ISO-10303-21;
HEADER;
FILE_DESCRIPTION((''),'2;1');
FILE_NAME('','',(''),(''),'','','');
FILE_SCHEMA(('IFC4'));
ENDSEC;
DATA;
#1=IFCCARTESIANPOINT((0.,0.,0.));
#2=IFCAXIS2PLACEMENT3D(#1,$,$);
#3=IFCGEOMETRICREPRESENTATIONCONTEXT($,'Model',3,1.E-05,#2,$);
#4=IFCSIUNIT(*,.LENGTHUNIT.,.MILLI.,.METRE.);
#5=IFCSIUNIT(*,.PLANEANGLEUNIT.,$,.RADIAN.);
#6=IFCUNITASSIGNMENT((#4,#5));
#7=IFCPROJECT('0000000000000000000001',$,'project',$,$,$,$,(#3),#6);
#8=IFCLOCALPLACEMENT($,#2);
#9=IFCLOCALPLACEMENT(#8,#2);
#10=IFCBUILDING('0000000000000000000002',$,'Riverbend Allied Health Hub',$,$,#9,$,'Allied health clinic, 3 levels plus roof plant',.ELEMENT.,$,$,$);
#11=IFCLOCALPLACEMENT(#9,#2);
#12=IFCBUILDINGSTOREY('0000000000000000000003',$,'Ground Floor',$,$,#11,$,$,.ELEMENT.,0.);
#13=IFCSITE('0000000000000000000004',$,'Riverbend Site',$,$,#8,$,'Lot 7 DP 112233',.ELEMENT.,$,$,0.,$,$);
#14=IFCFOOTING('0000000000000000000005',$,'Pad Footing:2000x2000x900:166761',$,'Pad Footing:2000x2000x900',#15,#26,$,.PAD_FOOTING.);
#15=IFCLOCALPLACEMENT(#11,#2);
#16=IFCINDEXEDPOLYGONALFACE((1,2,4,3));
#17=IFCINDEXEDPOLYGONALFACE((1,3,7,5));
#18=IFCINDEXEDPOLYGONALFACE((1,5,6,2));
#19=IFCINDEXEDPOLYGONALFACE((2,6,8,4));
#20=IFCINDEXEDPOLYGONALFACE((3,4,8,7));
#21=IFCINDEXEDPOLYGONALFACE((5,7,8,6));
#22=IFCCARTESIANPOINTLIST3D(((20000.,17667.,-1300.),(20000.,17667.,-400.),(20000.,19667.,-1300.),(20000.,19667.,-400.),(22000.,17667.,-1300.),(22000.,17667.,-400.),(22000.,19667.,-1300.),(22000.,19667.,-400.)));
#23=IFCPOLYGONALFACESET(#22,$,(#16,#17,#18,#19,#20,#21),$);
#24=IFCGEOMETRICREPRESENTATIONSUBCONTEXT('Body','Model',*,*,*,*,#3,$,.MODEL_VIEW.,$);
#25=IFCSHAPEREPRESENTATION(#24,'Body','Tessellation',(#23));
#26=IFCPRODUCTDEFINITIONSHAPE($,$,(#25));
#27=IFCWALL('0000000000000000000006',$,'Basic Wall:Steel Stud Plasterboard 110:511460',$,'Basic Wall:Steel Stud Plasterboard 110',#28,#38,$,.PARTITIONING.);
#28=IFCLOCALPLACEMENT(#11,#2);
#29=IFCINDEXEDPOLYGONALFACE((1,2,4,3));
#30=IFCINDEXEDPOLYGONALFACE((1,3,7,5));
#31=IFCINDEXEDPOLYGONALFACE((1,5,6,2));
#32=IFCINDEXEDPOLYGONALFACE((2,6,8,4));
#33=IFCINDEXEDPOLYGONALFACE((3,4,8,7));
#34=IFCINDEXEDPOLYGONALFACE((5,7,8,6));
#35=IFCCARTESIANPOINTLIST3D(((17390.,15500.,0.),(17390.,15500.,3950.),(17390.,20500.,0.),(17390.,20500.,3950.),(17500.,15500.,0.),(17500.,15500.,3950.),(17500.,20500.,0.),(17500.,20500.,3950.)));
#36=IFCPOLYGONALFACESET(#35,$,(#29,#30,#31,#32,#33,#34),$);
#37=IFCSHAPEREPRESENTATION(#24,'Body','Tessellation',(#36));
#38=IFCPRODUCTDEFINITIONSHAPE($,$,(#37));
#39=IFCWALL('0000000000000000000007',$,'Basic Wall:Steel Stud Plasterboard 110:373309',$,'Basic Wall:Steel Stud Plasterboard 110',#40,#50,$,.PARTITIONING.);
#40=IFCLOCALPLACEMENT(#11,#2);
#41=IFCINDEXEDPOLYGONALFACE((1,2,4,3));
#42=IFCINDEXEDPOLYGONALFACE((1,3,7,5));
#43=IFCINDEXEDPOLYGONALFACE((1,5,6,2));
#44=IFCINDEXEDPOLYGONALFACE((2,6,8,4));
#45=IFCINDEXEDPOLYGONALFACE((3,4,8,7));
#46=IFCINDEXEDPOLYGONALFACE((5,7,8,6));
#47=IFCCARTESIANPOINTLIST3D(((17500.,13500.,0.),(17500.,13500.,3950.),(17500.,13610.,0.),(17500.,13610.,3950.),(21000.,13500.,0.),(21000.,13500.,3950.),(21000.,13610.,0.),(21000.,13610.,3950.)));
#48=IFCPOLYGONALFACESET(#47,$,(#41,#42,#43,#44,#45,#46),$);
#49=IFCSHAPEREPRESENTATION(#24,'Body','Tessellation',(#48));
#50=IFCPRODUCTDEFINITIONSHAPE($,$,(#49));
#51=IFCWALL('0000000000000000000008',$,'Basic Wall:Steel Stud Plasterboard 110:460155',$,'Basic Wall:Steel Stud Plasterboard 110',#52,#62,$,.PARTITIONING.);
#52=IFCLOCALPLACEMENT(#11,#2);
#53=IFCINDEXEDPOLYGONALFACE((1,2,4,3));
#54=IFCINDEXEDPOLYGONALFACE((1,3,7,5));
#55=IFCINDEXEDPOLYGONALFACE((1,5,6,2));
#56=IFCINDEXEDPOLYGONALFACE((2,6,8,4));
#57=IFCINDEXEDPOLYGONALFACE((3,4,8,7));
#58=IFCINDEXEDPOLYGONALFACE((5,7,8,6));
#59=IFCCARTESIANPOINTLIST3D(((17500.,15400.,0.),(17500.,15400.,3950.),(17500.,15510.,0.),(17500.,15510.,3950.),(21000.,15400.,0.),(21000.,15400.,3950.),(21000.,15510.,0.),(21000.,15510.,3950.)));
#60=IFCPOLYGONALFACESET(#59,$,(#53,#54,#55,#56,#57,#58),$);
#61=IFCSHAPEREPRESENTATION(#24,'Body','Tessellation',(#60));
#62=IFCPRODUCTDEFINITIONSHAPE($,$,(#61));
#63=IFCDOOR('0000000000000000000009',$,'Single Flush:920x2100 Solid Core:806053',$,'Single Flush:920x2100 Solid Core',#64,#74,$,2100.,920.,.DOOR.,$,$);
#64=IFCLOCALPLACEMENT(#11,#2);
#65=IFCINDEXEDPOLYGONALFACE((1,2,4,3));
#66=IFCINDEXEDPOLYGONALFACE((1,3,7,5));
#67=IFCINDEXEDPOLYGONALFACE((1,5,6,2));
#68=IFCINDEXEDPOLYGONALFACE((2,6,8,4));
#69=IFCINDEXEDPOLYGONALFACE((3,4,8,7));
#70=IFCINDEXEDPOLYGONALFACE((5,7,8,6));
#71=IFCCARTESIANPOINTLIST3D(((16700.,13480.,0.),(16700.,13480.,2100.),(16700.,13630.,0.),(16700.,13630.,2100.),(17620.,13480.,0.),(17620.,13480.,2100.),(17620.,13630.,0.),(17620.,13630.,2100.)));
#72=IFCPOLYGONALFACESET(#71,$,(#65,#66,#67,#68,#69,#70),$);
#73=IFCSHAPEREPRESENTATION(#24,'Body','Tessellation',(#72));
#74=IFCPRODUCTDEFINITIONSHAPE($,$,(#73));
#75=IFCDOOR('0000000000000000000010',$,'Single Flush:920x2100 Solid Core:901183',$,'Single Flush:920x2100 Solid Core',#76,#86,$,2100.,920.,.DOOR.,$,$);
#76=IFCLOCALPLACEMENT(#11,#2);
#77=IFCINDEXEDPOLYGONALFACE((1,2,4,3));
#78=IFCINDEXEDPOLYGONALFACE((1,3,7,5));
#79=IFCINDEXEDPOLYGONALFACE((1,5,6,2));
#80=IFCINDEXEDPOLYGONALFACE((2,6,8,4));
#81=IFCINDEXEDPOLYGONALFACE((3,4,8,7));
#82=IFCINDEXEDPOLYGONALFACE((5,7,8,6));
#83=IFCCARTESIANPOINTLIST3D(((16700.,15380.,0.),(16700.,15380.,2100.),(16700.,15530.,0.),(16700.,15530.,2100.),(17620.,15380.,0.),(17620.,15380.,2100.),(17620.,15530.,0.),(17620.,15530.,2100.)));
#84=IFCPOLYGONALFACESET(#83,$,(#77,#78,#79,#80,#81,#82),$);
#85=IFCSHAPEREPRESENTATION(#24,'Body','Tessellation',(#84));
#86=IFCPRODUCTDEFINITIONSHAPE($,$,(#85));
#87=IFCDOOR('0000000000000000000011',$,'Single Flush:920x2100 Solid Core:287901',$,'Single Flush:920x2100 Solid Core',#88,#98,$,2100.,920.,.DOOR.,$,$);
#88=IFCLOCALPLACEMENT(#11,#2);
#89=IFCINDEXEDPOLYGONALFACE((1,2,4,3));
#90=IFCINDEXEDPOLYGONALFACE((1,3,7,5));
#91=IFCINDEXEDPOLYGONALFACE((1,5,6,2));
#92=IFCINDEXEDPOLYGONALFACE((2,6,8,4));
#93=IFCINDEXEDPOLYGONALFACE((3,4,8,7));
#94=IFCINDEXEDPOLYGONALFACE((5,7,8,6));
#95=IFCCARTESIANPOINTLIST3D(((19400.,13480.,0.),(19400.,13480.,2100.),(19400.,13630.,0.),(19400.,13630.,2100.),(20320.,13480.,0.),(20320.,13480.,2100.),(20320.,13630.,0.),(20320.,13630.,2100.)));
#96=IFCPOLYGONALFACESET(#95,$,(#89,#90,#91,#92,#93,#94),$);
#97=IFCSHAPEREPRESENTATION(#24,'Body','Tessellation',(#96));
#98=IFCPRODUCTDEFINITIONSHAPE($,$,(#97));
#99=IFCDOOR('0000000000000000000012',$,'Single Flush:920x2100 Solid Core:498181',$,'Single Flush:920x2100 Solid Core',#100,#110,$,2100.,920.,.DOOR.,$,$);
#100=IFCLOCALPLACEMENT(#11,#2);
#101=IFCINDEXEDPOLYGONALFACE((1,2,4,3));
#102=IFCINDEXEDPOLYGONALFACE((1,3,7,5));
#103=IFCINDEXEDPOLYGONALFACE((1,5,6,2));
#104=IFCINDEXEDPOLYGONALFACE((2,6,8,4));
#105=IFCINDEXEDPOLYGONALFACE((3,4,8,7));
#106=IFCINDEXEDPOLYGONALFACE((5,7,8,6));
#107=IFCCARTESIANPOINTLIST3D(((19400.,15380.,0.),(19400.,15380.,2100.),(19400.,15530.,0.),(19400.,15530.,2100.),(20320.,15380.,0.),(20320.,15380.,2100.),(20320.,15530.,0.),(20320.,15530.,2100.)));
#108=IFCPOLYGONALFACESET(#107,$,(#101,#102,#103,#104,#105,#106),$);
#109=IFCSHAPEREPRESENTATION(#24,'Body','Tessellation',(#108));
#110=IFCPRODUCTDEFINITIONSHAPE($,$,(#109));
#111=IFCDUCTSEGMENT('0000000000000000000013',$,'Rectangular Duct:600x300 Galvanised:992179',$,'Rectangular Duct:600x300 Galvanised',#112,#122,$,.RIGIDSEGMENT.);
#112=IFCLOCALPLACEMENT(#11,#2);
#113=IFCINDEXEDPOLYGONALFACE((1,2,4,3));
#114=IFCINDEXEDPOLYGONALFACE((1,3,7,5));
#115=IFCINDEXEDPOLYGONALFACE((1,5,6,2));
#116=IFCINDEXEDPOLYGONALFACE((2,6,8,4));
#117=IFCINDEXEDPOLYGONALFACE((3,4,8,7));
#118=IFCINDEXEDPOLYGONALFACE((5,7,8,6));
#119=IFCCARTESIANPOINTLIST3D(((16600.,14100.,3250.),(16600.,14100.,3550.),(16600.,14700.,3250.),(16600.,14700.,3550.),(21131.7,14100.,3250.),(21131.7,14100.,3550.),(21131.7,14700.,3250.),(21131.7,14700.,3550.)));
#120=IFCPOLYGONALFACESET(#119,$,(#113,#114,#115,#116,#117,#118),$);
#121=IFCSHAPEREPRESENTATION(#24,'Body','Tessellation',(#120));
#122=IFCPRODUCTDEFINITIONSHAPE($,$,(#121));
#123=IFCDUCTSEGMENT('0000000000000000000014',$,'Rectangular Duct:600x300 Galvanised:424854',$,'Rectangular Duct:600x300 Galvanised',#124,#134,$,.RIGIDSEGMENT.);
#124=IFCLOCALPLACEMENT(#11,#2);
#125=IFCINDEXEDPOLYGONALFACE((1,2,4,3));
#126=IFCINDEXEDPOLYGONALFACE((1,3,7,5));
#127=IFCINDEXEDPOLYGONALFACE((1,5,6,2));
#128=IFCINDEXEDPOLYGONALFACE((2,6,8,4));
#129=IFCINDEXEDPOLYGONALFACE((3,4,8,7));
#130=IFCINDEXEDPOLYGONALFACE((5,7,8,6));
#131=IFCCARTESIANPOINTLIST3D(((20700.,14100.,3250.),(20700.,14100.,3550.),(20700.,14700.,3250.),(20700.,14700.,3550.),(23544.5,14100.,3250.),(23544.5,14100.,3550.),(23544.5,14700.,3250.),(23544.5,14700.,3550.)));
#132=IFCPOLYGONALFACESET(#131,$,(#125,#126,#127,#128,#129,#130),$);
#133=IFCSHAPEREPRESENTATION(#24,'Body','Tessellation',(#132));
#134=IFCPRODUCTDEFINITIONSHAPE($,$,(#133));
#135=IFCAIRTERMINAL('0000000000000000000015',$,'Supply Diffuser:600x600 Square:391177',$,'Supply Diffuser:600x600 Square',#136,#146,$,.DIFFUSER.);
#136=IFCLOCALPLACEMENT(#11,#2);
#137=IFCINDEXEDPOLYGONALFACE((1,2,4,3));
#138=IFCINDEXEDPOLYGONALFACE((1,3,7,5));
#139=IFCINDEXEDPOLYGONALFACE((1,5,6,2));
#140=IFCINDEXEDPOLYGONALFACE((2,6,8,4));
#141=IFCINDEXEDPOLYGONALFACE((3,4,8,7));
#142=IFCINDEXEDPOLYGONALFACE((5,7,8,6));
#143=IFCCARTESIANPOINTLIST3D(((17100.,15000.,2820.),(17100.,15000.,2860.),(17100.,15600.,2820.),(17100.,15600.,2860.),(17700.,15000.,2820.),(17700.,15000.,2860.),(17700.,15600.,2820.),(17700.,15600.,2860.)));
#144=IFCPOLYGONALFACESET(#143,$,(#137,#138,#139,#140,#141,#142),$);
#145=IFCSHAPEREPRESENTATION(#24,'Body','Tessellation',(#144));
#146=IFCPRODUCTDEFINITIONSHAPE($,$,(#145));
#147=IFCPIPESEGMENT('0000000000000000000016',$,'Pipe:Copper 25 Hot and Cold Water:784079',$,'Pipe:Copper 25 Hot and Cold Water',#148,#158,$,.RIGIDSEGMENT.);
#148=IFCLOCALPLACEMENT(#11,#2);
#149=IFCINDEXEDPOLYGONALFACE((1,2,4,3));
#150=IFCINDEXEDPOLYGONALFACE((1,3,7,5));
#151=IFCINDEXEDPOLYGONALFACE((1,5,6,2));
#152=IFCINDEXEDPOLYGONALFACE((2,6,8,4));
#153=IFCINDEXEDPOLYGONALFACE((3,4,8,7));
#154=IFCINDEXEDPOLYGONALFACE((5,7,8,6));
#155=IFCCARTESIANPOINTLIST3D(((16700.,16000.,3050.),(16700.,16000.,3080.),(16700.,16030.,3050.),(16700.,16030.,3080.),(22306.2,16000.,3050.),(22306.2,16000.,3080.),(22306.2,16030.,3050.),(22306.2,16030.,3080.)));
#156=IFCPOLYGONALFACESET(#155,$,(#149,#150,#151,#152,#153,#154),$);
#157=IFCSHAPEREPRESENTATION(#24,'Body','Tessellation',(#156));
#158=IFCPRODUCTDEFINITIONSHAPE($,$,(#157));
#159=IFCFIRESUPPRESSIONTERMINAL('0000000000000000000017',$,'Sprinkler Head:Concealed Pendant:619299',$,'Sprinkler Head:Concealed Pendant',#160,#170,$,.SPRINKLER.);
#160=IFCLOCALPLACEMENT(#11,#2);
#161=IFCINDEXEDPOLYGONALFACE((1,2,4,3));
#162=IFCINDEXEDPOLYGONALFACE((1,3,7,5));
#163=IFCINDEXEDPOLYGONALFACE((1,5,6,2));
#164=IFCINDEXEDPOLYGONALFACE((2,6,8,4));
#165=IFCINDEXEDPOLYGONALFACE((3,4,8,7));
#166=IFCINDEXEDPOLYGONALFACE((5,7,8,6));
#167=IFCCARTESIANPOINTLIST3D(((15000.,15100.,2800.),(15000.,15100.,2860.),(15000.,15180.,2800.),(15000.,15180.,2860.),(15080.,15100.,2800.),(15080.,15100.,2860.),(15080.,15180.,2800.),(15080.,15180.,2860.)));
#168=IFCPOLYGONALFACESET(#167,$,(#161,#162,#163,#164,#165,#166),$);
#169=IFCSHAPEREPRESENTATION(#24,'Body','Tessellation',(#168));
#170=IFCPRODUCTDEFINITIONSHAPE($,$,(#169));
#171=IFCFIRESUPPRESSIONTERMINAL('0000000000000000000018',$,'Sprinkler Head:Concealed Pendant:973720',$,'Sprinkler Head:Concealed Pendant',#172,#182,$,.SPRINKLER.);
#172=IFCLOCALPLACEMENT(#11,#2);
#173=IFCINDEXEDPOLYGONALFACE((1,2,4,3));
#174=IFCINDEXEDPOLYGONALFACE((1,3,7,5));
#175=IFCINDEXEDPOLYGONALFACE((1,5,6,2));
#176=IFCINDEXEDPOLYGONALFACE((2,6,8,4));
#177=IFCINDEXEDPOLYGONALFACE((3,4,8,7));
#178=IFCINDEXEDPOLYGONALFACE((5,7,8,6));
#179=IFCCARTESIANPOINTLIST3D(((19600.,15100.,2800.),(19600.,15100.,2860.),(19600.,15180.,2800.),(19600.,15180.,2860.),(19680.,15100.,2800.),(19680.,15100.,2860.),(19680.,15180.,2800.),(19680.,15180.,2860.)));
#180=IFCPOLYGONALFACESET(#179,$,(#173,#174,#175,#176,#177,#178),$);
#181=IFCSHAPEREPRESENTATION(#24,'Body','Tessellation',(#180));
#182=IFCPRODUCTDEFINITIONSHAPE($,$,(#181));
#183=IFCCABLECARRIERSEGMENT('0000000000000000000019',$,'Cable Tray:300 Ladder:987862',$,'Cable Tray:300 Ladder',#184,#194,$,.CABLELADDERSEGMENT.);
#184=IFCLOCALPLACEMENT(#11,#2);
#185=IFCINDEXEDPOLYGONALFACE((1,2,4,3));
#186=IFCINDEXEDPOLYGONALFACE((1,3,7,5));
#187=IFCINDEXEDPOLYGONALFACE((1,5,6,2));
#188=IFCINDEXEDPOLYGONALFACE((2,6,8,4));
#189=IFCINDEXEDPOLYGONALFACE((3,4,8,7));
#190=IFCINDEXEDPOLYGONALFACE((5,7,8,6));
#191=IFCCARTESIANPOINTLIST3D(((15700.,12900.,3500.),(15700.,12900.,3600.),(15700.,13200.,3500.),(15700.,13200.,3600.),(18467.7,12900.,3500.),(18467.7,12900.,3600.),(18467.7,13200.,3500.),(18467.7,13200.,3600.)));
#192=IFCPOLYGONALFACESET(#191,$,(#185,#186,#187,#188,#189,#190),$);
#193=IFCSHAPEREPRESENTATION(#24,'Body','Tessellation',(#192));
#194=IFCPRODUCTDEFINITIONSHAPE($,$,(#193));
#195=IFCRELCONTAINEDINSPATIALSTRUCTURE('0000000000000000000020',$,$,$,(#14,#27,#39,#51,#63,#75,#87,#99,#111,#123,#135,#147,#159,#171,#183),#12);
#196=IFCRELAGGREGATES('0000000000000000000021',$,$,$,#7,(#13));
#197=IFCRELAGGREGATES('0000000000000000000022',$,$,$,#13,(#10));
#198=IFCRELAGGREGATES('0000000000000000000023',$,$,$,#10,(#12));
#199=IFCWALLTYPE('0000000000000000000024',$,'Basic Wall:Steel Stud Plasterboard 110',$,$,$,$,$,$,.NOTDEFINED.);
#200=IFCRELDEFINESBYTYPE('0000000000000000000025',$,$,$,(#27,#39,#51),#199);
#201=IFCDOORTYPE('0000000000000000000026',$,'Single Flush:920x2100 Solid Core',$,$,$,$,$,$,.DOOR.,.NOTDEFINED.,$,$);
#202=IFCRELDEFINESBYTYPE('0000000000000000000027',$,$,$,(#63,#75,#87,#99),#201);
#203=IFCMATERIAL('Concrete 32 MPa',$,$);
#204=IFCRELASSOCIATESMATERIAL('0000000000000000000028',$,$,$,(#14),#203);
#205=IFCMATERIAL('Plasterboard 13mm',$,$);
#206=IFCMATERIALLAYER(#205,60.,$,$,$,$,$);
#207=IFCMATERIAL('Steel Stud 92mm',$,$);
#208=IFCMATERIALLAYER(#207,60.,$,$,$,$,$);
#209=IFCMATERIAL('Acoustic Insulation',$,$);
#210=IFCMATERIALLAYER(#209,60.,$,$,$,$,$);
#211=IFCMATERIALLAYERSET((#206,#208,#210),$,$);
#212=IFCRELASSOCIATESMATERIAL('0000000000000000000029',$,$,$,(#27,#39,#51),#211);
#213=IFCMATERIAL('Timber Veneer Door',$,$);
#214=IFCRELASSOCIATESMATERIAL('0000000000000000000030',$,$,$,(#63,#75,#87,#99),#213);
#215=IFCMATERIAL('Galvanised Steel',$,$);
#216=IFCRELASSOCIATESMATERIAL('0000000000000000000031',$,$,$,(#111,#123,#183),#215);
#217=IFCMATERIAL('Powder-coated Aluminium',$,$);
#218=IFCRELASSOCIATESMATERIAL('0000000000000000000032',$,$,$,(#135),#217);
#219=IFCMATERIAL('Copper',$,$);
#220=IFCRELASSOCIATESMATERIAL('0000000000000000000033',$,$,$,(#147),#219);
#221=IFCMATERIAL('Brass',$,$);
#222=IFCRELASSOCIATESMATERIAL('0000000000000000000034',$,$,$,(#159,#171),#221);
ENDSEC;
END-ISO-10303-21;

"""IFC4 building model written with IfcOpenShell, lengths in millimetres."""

from ifc_helpers import new_model, si_unit, frame, frame_2d, origin, place, context, subcontext, project, spatial, rectangle, extrude, material, layer, layer_set, layer_usage, type_object, element, save


model = new_model("IFC4")

# Units and contexts
model_context = context("Model", 3, precision=1e-05, world=origin())
body_context = subcontext(model_context, "Body", "Model", "MODEL_VIEW")
ifc_project = project(units=[si_unit("LENGTHUNIT", "METRE", prefix="MILLI"), si_unit("PLANEANGLEUNIT", "RADIAN")], contexts=[model_context])

# Site, building, storey
site_placement = place(None, origin())
site = spatial("IfcSite", under=ifc_project, at=site_placement, Name="Riverbend Site", LongName="Lot 7 DP 112233", CompositionType="ELEMENT", RefElevation=0.0)
building_placement = place(site_placement, origin())
building = spatial("IfcBuilding", under=site, at=building_placement, Name="Riverbend Allied Health Hub", LongName="Allied health clinic, 3 levels plus roof plant", CompositionType="ELEMENT")
storey_placement = place(building_placement, origin())
storey = spatial("IfcBuildingStorey", under=building, at=storey_placement, Name="Ground Floor", CompositionType="ELEMENT", Elevation=0.0)

# Footing
ifc_material_1 = material(Name="Concrete 32 MPa")
footing_placement = place(storey_placement, frame((20000.0, 17667.0, -1300.0)))
element("IfcFooting", 1, at=footing_placement, inside=storey, material=ifc_material_1, Name="Pad Footing:2000x2000x900:166761", ObjectType="Pad Footing:2000x2000x900", PredefinedType="PAD_FOOTING", context=body_context, shape_type="SweptSolid", body=[
    extrude(rectangle(XDim=2000.0, YDim=2000.0, at=frame_2d((1000.0, 1000.0))), origin(), (0.0, 0.0, 1.0), 900.0),
])

# Walls
ifc_material_2 = material(Name="Plasterboard 13mm")
ifc_layer_1 = layer(ifc_material_2, 60.0)
ifc_material_3 = material(Name="Steel Stud 92mm")
ifc_layer_2 = layer(ifc_material_3, 60.0)
ifc_material_4 = material(Name="Acoustic Insulation")
ifc_layer_3 = layer(ifc_material_4, 60.0)
ifc_layer_set = layer_set([ifc_layer_1, ifc_layer_2, ifc_layer_3])
ifc_layer_usage = layer_usage(ifc_layer_set, "AXIS2", "POSITIVE", 0.0)
wall_type = type_object("IfcWallType", Name="Basic Wall:Steel Stud Plasterboard 110", PredefinedType="NOTDEFINED")
wall_placement = place(storey_placement, frame((17500.0, 15500.0, 0.0), z_axis=(0.0, 0.0, 1.0), x_axis=(0.0, 1.0, 0.0)))
element("IfcWall", 2, at=wall_placement, inside=storey, type_object=wall_type, material=ifc_layer_usage, Name="Basic Wall:Steel Stud Plasterboard 110:511460", ObjectType="Basic Wall:Steel Stud Plasterboard 110", PredefinedType="PARTITIONING", context=body_context, shape_type="SweptSolid", body=[
    extrude(rectangle(XDim=5000.0, YDim=110.0, at=frame_2d((2500.0, 55.0))), origin(), (0.0, 0.0, 1.0), 3950.0),
])
for number, where, name in (
    (3, (17500.0, 13500.0, 0.0), "Basic Wall:Steel Stud Plasterboard 110:373309"),
    (4, (17500.0, 15400.0, 0.0), "Basic Wall:Steel Stud Plasterboard 110:460155"),
):
    element("IfcWall", number, at=place(storey_placement, frame(where)), inside=storey, type_object=wall_type, material=ifc_layer_usage, Name=name, ObjectType="Basic Wall:Steel Stud Plasterboard 110", PredefinedType="PARTITIONING", context=body_context, shape_type="SweptSolid", body=[
        extrude(rectangle(XDim=3500.0, YDim=110.0, at=frame_2d((1750.0, 55.0))), origin(), (0.0, 0.0, 1.0), 3950.0),
    ])

# Doors
ifc_material_5 = material(Name="Timber Veneer Door")
door_type = type_object("IfcDoorType", Name="Single Flush:920x2100 Solid Core", OperationType="NOTDEFINED", PredefinedType="DOOR")
for number, where, name in (
    (5, (16700.0, 13480.0, 0.0), "Single Flush:920x2100 Solid Core:806053"),
    (6, (16700.0, 15380.0, 0.0), "Single Flush:920x2100 Solid Core:901183"),
    (7, (19400.0, 13480.0, 0.0), "Single Flush:920x2100 Solid Core:287901"),
    (8, (19400.0, 15380.0, 0.0), "Single Flush:920x2100 Solid Core:498181"),
):
    element("IfcDoor", number, at=place(storey_placement, frame(where)), inside=storey, type_object=door_type, material=ifc_material_5, Name=name, ObjectType="Single Flush:920x2100 Solid Core", OverallHeight=2100.0, OverallWidth=920.0, PredefinedType="DOOR", context=body_context, shape_type="SweptSolid", body=[
        extrude(rectangle(XDim=920.0, YDim=150.0, at=frame_2d((460.0, 75.0))), origin(), (0.0, 0.0, 1.0), 2100.0),
    ])

# Duct segments
ifc_material_6 = material(Name="Galvanised Steel")
duct_segment_1_placement = place(storey_placement, frame((16600.0, 14100.0, 3250.0)))
element("IfcDuctSegment", 9, at=duct_segment_1_placement, inside=storey, material=ifc_material_6, Name="Rectangular Duct:600x300 Galvanised:992179", ObjectType="Rectangular Duct:600x300 Galvanised", PredefinedType="RIGIDSEGMENT", context=body_context, shape_type="SweptSolid", body=[
    extrude(rectangle(XDim=4531.7, YDim=600.0, at=frame_2d((2265.9, 300.0))), origin(), (0.0, 0.0, 1.0), 300.0),
])
duct_segment_2_placement = place(storey_placement, frame((20700.0, 14100.0, 3250.0)))
element("IfcDuctSegment", 10, at=duct_segment_2_placement, inside=storey, material=ifc_material_6, Name="Rectangular Duct:600x300 Galvanised:424854", ObjectType="Rectangular Duct:600x300 Galvanised", PredefinedType="RIGIDSEGMENT", context=body_context, shape_type="SweptSolid", body=[
    extrude(rectangle(XDim=2844.5, YDim=600.0, at=frame_2d((1422.2, 300.0))), origin(), (0.0, 0.0, 1.0), 300.0),
])

# Air terminal
ifc_material_7 = material(Name="Powder-coated Aluminium")
air_terminal_placement = place(storey_placement, frame((17100.0, 15000.0, 2820.0)))
element("IfcAirTerminal", 11, at=air_terminal_placement, inside=storey, material=ifc_material_7, Name="Supply Diffuser:600x600 Square:391177", ObjectType="Supply Diffuser:600x600 Square", PredefinedType="DIFFUSER", context=body_context, shape_type="SweptSolid", body=[
    extrude(rectangle(XDim=600.0, YDim=600.0, at=frame_2d((300.0, 300.0))), origin(), (0.0, 0.0, 1.0), 40.0),
])

# Pipe segment
ifc_material_8 = material(Name="Copper")
pipe_segment_placement = place(storey_placement, frame((16700.0, 16000.0, 3050.0)))
element("IfcPipeSegment", 12, at=pipe_segment_placement, inside=storey, material=ifc_material_8, Name="Pipe:Copper 25 Hot and Cold Water:784079", ObjectType="Pipe:Copper 25 Hot and Cold Water", PredefinedType="RIGIDSEGMENT", context=body_context, shape_type="SweptSolid", body=[
    extrude(rectangle(XDim=5606.2, YDim=30.0, at=frame_2d((2803.1, 15.0))), origin(), (0.0, 0.0, 1.0), 30.0),
])

# Fire suppression terminals
ifc_material_9 = material(Name="Brass")
for number, where, name in (
    (13, (15000.0, 15100.0, 2800.0), "Sprinkler Head:Concealed Pendant:619299"),
    (14, (19600.0, 15100.0, 2800.0), "Sprinkler Head:Concealed Pendant:973720"),
):
    element("IfcFireSuppressionTerminal", number, at=place(storey_placement, frame(where)), inside=storey, material=ifc_material_9, Name=name, ObjectType="Sprinkler Head:Concealed Pendant", PredefinedType="SPRINKLER", context=body_context, shape_type="SweptSolid", body=[
        extrude(rectangle(XDim=80.0, YDim=80.0, at=frame_2d((40.0, 40.0))), origin(), (0.0, 0.0, 1.0), 60.0),
    ])

# Cable carrier segment
cable_carrier_segment_placement = place(storey_placement, frame((15700.0, 12900.0, 3500.0)))
element("IfcCableCarrierSegment", 15, at=cable_carrier_segment_placement, inside=storey, material=ifc_material_6, Name="Cable Tray:300 Ladder:987862", ObjectType="Cable Tray:300 Ladder", PredefinedType="CABLELADDERSEGMENT", context=body_context, shape_type="SweptSolid", body=[
    extrude(rectangle(XDim=2767.7, YDim=300.0, at=frame_2d((1383.8, 150.0))), origin(), (0.0, 0.0, 1.0), 100.0),
])

save(model, "model.ifc")
